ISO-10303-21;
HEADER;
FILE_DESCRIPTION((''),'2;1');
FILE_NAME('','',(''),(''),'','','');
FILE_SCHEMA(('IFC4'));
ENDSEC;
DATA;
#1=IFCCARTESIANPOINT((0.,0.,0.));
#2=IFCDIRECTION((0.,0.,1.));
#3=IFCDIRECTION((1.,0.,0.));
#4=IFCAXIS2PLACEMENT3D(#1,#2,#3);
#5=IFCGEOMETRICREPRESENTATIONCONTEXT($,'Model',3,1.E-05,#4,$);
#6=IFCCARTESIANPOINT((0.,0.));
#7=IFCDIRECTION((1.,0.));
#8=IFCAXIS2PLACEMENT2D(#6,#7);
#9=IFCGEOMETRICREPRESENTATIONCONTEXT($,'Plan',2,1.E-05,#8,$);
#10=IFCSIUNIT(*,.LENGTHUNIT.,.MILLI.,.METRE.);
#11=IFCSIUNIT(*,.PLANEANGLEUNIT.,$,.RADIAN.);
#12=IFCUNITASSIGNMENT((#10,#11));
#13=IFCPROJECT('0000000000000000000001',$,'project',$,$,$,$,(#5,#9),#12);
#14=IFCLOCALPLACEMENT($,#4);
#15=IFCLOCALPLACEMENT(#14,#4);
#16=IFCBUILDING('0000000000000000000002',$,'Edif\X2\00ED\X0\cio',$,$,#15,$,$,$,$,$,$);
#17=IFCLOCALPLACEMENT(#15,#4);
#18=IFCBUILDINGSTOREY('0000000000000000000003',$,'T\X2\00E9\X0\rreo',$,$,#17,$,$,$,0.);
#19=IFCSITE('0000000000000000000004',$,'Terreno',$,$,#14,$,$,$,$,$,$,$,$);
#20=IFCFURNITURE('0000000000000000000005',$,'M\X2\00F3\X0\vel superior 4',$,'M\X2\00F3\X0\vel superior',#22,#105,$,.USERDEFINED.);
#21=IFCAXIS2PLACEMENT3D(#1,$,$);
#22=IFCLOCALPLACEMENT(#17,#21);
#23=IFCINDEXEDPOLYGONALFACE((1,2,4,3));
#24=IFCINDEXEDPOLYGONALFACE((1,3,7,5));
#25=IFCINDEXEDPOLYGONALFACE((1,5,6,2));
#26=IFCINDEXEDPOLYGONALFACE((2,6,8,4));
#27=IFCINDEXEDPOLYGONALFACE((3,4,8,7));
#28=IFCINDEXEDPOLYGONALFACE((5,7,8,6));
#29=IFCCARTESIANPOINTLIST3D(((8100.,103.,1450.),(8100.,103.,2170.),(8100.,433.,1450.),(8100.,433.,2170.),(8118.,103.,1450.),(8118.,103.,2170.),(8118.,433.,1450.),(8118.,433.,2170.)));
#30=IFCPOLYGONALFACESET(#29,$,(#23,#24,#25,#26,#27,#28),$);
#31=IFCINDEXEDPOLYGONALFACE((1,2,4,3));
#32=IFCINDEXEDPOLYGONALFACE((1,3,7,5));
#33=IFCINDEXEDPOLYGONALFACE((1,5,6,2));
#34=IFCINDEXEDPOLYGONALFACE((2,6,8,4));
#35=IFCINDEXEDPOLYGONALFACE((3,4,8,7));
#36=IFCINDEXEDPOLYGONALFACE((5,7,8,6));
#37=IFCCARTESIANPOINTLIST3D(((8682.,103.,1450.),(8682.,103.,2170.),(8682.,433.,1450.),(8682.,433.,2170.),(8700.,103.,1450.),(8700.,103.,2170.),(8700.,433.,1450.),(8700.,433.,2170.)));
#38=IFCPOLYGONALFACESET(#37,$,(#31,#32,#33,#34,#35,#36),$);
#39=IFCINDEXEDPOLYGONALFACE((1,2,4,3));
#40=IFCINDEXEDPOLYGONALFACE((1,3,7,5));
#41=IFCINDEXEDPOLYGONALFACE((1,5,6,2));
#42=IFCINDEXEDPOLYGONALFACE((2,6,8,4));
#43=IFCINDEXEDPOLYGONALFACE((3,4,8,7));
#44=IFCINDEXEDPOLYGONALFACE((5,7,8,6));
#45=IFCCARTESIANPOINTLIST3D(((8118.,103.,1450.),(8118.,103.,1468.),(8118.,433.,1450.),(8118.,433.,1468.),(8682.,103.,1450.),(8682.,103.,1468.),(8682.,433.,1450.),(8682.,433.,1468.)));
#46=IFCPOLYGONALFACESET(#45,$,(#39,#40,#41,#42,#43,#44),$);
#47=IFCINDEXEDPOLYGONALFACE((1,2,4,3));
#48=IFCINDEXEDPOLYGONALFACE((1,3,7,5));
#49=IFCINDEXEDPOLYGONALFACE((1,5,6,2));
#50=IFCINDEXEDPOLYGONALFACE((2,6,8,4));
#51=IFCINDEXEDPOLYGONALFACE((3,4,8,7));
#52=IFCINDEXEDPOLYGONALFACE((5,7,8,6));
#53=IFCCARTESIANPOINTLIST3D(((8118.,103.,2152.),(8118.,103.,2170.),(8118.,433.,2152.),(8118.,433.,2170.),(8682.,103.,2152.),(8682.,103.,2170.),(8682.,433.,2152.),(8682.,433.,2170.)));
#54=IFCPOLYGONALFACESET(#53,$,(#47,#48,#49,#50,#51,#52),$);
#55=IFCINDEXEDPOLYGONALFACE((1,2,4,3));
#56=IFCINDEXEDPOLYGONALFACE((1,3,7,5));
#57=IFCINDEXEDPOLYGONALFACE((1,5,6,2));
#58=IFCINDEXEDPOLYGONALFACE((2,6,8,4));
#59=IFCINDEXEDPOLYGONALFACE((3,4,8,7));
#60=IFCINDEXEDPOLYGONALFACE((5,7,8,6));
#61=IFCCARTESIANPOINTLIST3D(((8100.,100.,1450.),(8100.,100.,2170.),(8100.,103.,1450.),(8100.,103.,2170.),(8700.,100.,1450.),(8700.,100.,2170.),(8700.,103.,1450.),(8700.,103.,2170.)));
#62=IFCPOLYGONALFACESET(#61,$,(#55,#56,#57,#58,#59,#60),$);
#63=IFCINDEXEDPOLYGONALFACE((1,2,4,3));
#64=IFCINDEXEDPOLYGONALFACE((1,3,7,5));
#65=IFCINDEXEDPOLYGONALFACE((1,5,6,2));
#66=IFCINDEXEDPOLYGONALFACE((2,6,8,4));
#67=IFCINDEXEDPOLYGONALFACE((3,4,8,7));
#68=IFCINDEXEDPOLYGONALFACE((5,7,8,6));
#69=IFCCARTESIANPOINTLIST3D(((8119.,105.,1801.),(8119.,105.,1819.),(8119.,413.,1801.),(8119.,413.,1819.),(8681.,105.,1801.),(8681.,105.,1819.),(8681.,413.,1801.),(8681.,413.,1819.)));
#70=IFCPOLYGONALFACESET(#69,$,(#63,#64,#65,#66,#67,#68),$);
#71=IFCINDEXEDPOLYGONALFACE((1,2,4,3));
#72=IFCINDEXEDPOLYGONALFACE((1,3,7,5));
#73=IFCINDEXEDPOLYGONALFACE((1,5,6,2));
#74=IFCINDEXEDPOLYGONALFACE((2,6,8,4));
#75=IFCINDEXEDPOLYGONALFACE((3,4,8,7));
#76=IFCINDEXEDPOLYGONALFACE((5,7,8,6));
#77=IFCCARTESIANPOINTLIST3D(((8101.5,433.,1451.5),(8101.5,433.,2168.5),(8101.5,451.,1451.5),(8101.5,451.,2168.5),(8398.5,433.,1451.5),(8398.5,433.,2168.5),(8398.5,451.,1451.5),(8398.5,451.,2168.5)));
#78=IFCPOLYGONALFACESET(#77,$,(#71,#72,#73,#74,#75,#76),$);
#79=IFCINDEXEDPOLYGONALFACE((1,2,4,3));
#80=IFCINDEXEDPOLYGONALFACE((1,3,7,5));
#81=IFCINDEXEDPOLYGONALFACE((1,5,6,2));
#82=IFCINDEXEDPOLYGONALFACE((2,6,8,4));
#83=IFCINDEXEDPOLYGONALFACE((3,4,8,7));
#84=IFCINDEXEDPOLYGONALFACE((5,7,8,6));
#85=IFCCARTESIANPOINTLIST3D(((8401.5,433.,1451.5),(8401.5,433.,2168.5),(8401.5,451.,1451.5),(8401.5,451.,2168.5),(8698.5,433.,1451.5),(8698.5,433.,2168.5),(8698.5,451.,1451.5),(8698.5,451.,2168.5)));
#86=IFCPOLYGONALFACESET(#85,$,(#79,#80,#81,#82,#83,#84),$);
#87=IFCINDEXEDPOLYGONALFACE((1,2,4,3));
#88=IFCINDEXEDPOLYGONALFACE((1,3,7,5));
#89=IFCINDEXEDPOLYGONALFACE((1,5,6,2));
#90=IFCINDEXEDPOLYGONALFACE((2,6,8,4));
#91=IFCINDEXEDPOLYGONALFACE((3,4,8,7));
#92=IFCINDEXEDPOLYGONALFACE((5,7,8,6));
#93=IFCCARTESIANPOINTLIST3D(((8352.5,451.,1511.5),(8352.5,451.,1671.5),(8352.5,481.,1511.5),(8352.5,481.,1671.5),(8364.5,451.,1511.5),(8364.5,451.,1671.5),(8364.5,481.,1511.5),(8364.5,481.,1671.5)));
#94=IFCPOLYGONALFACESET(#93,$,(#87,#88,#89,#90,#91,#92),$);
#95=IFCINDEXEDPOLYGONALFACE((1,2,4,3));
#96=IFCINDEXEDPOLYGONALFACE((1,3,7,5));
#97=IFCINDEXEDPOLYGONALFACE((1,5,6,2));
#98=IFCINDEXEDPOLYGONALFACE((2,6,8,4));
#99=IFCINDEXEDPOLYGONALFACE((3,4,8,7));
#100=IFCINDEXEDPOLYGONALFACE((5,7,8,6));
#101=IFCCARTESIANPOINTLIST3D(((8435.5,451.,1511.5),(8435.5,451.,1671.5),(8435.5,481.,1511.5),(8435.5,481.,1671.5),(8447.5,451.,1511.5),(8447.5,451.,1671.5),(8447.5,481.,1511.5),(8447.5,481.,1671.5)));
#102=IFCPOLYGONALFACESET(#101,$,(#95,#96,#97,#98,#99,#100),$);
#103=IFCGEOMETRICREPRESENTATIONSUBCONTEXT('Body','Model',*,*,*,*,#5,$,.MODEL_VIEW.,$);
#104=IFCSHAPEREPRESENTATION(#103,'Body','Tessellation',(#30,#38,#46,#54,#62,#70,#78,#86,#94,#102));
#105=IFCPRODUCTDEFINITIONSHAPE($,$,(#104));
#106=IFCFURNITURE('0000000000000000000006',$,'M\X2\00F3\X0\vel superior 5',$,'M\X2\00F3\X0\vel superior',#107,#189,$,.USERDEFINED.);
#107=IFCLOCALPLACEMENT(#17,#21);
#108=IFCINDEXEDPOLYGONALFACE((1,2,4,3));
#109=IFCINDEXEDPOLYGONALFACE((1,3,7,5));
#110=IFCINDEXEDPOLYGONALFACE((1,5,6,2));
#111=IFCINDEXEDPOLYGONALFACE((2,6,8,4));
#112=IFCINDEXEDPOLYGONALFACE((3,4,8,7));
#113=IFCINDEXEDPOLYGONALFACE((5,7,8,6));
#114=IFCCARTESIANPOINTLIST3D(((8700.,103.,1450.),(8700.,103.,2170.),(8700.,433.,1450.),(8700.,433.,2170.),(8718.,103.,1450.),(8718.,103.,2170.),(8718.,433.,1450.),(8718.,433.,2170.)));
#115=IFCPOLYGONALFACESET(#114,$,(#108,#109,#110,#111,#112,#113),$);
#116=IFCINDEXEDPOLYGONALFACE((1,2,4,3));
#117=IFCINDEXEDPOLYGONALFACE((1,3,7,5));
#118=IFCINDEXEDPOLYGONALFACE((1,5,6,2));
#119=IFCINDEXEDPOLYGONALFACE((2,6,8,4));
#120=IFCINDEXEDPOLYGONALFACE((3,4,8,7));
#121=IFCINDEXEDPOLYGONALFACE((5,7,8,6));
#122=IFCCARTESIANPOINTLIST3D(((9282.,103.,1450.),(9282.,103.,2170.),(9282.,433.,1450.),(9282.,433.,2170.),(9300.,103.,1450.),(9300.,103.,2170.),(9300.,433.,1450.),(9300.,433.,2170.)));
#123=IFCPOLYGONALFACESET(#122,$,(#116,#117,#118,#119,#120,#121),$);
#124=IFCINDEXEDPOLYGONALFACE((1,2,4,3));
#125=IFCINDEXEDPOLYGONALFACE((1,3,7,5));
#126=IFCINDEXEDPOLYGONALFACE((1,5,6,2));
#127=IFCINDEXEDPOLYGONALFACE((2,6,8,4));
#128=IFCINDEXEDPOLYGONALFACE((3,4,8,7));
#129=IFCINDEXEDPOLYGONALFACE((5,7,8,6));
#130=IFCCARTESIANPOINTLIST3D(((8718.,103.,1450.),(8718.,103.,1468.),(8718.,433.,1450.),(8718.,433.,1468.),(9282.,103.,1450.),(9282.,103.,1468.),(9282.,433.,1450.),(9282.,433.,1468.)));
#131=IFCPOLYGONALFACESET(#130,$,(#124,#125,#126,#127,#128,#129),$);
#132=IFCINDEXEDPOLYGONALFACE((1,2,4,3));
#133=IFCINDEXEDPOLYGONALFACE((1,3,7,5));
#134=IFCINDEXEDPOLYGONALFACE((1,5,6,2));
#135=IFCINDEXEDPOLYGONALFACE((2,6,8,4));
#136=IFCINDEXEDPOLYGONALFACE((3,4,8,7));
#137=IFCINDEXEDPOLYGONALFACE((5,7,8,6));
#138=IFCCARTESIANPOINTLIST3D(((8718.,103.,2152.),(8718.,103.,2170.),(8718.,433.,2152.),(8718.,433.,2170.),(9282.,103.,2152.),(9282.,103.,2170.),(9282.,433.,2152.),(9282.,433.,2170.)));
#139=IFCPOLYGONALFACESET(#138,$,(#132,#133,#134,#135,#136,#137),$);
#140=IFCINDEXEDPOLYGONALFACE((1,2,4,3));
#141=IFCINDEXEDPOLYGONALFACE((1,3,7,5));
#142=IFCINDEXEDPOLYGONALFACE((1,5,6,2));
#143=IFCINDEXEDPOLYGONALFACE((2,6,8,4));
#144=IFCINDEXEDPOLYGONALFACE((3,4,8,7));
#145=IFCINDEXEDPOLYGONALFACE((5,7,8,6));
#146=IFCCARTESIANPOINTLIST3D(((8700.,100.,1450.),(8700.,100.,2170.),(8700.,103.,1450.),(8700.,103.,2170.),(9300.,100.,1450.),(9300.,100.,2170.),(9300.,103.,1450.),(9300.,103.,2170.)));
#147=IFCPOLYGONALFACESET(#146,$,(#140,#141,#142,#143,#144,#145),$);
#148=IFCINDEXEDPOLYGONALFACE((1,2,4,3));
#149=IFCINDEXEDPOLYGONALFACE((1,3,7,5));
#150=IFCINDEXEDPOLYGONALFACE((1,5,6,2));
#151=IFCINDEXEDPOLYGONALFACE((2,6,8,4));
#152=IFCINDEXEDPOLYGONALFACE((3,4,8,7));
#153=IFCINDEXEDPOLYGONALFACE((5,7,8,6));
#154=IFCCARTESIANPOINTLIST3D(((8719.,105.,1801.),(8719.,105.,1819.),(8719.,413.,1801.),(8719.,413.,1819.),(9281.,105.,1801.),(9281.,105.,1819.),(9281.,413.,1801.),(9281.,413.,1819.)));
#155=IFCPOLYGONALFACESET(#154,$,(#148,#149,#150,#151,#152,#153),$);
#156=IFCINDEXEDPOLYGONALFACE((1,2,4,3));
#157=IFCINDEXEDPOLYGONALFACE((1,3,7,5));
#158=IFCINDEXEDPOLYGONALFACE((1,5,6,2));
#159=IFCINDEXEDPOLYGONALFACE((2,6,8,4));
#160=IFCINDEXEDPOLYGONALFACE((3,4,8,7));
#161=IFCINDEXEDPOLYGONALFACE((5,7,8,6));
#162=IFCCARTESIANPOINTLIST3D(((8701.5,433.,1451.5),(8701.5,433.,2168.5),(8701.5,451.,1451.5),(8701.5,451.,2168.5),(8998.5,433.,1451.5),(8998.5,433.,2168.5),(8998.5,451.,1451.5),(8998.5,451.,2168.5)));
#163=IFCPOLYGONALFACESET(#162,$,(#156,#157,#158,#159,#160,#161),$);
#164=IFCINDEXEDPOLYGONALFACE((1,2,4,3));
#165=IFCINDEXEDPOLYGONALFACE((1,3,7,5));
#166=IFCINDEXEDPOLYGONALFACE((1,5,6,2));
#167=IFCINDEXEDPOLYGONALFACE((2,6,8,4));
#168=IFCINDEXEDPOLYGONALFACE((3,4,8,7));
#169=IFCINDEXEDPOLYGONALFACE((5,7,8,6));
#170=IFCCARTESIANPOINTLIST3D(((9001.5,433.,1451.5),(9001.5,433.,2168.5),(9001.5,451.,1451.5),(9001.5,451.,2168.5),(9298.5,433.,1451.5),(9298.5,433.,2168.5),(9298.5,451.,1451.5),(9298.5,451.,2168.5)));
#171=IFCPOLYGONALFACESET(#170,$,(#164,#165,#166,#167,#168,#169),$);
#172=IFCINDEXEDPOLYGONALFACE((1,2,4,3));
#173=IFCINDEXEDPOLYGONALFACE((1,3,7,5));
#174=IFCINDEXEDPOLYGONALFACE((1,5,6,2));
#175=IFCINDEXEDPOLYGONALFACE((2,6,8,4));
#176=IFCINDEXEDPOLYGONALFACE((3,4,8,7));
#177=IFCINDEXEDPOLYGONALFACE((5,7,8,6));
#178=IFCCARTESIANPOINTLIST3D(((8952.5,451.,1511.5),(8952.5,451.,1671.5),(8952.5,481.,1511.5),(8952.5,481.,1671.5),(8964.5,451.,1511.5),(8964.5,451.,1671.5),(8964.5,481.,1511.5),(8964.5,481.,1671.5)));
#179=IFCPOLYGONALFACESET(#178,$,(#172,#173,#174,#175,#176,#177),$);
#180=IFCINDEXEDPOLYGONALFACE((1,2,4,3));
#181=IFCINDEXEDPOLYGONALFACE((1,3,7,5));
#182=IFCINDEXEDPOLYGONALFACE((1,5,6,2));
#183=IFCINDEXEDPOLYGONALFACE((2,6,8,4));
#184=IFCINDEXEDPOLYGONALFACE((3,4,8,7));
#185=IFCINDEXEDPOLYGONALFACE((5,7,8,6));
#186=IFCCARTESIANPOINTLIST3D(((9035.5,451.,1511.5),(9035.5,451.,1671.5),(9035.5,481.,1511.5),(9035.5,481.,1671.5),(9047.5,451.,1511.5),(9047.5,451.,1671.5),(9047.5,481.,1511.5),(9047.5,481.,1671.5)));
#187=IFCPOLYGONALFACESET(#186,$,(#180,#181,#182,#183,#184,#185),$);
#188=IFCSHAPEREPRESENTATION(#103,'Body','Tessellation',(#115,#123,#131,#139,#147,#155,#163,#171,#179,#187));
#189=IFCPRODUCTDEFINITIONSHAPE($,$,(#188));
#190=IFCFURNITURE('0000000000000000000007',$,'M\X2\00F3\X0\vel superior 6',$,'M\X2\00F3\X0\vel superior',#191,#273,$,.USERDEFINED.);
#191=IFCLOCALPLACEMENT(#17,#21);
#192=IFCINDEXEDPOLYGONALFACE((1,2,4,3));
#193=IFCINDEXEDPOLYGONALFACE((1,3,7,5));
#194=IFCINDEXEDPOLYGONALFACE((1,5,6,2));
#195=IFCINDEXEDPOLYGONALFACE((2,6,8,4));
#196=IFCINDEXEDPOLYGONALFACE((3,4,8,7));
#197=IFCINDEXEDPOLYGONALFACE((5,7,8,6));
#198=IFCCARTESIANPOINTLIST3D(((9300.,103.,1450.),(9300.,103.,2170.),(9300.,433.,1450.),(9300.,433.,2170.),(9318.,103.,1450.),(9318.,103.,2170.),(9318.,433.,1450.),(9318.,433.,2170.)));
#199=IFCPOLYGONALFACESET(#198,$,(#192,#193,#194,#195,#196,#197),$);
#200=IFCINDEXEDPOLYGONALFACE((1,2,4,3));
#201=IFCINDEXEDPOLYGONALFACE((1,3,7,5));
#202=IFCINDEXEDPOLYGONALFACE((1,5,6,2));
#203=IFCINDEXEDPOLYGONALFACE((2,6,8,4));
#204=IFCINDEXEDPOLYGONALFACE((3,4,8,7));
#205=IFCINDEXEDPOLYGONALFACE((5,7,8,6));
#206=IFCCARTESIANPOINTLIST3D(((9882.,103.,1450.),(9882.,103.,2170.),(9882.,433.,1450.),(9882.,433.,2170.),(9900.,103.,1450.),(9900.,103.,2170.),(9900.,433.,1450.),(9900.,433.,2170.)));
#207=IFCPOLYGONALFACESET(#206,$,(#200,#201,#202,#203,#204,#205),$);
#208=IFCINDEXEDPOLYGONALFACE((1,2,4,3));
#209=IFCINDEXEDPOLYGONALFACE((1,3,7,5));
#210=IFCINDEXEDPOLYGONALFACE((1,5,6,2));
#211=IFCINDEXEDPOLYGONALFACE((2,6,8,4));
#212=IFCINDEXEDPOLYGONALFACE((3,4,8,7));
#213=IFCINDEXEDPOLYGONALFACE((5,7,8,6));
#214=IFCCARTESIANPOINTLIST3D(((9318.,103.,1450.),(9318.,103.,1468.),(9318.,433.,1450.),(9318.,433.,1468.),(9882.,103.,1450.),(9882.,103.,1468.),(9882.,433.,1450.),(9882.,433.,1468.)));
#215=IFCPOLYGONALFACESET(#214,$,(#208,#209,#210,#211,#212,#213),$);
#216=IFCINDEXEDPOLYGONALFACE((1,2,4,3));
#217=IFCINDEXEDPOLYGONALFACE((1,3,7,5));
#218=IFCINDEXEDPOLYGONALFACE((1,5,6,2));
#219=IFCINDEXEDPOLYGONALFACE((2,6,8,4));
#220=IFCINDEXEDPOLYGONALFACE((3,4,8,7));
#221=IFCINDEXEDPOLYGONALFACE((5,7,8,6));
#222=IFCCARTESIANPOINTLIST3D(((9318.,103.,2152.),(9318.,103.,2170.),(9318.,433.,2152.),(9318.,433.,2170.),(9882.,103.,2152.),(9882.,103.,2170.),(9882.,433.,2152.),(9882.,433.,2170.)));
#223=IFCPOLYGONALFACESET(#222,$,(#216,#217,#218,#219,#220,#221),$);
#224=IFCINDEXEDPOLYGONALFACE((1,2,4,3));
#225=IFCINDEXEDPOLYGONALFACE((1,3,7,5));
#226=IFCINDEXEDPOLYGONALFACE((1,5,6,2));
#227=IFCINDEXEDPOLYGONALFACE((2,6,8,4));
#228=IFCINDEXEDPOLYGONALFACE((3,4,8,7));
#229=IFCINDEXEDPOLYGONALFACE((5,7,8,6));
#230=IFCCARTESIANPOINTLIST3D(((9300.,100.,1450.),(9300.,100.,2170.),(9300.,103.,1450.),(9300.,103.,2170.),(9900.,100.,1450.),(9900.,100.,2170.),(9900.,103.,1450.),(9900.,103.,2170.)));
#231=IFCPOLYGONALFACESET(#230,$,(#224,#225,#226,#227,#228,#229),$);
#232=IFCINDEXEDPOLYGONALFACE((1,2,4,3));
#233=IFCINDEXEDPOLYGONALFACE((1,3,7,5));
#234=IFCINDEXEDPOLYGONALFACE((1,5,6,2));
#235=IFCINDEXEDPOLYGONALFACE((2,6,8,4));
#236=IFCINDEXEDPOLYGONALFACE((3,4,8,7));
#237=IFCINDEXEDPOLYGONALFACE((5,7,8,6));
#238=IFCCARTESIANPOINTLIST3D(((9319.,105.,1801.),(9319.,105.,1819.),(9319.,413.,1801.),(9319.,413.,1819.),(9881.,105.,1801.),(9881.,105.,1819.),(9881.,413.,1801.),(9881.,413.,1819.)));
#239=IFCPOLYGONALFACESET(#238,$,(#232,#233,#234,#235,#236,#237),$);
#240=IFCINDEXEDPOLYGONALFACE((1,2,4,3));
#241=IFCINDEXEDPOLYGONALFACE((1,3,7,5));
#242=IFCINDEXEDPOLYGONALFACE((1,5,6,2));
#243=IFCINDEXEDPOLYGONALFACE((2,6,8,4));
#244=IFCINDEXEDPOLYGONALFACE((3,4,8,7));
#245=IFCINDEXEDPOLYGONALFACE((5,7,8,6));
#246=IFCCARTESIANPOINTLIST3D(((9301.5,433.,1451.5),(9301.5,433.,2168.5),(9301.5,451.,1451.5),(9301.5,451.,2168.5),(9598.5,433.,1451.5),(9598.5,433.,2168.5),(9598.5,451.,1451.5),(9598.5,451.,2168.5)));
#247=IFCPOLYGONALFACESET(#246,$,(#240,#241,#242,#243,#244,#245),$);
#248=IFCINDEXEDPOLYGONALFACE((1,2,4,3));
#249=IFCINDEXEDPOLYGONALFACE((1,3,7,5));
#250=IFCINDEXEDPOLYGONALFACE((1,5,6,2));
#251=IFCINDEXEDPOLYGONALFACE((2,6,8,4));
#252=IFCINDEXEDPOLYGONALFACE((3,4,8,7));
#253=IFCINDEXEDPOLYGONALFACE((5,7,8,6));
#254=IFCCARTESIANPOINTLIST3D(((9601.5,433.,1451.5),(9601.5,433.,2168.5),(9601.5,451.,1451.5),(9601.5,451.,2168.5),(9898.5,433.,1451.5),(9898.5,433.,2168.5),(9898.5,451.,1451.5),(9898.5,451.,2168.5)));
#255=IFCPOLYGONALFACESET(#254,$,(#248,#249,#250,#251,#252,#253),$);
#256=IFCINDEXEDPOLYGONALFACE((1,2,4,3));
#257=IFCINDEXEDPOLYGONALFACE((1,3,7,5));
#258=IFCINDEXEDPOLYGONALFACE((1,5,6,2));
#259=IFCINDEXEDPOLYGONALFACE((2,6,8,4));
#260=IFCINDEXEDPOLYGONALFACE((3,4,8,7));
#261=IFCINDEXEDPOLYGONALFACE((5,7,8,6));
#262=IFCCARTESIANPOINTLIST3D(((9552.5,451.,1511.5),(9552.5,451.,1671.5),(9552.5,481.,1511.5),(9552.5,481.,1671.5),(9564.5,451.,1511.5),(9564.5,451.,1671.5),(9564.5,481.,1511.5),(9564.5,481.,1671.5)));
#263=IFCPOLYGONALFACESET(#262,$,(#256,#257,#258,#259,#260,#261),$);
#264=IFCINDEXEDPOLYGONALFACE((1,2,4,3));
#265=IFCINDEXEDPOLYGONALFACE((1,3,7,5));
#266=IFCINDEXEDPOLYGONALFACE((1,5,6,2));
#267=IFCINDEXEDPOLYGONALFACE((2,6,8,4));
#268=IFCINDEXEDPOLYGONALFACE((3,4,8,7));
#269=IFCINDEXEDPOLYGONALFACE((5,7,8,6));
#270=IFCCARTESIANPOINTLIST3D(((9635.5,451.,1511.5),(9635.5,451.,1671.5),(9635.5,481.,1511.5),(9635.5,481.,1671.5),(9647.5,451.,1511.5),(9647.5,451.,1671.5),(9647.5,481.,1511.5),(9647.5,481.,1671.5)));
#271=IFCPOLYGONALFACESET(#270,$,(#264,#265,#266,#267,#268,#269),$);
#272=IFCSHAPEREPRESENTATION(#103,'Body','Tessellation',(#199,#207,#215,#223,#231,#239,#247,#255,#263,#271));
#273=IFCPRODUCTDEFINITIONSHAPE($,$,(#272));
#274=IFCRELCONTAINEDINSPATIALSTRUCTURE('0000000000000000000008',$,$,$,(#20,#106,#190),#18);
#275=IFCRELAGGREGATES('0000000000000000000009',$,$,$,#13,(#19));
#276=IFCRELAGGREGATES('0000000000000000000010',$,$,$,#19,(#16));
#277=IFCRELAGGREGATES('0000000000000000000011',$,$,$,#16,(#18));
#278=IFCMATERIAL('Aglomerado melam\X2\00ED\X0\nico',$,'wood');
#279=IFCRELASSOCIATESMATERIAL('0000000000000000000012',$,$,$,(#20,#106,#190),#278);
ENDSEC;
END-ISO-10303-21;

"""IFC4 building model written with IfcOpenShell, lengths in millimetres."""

from ifc_helpers import new_model, si_unit, frame, frame_2d, origin_with_axes, origin_2d_with_axis, place, context, subcontext, project, spatial, rectangle, extrude, material, element, save


model = new_model("IFC4")

# Units and contexts
model_context = context("Model", 3, precision=1e-05, world=origin_with_axes())
plan_context = context("Plan", 2, precision=1e-05, world=origin_2d_with_axis())
body_context = subcontext(model_context, "Body", "Model", "MODEL_VIEW")
ifc_project = project(units=[si_unit("LENGTHUNIT", "METRE", prefix="MILLI"), si_unit("PLANEANGLEUNIT", "RADIAN")], contexts=[model_context, plan_context])

# Site, building, storey
site_placement = place(None, origin_with_axes())
site = spatial("IfcSite", under=ifc_project, at=site_placement, Name="Terreno")
building_placement = place(site_placement, origin_with_axes())
building = spatial("IfcBuilding", under=site, at=building_placement, Name="Edifício")
storey_placement = place(building_placement, origin_with_axes())
storey = spatial("IfcBuildingStorey", under=building, at=storey_placement, Name="Térreo", Elevation=0.0)

# Furniture
ifc_material_1 = material(Name="Aglomerado melamínico", Category="wood")
for number, where, z_axis, x_axis, name in (
    (1, (8100.0, 100.0, 0.0), (0.0, 0.0, 1.0), (1.0, 0.0, 0.0), "Móvel superior 4"),
    (2, (8700.0, 100.0, 0.0), (0.0, 0.0, 1.0), (1.0, 0.0, 0.0), "Móvel superior 5"),
    (3, (9300.0, 100.0, 0.0), (0.0, 0.0, 1.0), (1.0, 0.0, 0.0), "Móvel superior 6"),
):
    element("IfcFurniture", number, at=place(storey_placement, frame(where, z_axis=z_axis, x_axis=x_axis)), inside=storey, material=ifc_material_1, Name=name, ObjectType="Móvel superior", PredefinedType="USERDEFINED", context=body_context, shape_type="SweptSolid", body=[
        extrude(rectangle(XDim=18.0, YDim=330.0, at=frame_2d((9.0, 168.0))), frame((0.0, 0.0, 1450.0)), (0.0, 0.0, 1.0), 720.0),
        extrude(rectangle(XDim=18.0, YDim=330.0, at=frame_2d((591.0, 168.0))), frame((0.0, 0.0, 1450.0)), (0.0, 0.0, 1.0), 720.0),
        extrude(rectangle(XDim=564.0, YDim=330.0, at=frame_2d((300.0, 168.0))), frame((0.0, 0.0, 1450.0)), (0.0, 0.0, 1.0), 18.0),
        extrude(rectangle(XDim=564.0, YDim=330.0, at=frame_2d((300.0, 168.0))), frame((0.0, 0.0, 2152.0)), (0.0, 0.0, 1.0), 18.0),
        extrude(rectangle(XDim=600.0, YDim=3.0, at=frame_2d((300.0, 1.5))), frame((0.0, 0.0, 1450.0)), (0.0, 0.0, 1.0), 720.0),
        extrude(rectangle(XDim=562.0, YDim=308.0, at=frame_2d((300.0, 159.0))), frame((0.0, 0.0, 1801.0)), (0.0, 0.0, 1.0), 18.0),
        extrude(rectangle(XDim=297.0, YDim=18.0, at=frame_2d((150.0, 342.0))), frame((0.0, 0.0, 1451.5)), (0.0, 0.0, 1.0), 717.0),
        extrude(rectangle(XDim=297.0, YDim=18.0, at=frame_2d((450.0, 342.0))), frame((0.0, 0.0, 1451.5)), (0.0, 0.0, 1.0), 717.0),
        extrude(rectangle(XDim=12.0, YDim=30.0, at=frame_2d((258.5, 366.0))), frame((0.0, 0.0, 1511.5)), (0.0, 0.0, 1.0), 160.0),
        extrude(rectangle(XDim=12.0, YDim=30.0, at=frame_2d((341.5, 366.0))), frame((0.0, 0.0, 1511.5)), (0.0, 0.0, 1.0), 160.0),
    ])

save(model, "model.ifc")
